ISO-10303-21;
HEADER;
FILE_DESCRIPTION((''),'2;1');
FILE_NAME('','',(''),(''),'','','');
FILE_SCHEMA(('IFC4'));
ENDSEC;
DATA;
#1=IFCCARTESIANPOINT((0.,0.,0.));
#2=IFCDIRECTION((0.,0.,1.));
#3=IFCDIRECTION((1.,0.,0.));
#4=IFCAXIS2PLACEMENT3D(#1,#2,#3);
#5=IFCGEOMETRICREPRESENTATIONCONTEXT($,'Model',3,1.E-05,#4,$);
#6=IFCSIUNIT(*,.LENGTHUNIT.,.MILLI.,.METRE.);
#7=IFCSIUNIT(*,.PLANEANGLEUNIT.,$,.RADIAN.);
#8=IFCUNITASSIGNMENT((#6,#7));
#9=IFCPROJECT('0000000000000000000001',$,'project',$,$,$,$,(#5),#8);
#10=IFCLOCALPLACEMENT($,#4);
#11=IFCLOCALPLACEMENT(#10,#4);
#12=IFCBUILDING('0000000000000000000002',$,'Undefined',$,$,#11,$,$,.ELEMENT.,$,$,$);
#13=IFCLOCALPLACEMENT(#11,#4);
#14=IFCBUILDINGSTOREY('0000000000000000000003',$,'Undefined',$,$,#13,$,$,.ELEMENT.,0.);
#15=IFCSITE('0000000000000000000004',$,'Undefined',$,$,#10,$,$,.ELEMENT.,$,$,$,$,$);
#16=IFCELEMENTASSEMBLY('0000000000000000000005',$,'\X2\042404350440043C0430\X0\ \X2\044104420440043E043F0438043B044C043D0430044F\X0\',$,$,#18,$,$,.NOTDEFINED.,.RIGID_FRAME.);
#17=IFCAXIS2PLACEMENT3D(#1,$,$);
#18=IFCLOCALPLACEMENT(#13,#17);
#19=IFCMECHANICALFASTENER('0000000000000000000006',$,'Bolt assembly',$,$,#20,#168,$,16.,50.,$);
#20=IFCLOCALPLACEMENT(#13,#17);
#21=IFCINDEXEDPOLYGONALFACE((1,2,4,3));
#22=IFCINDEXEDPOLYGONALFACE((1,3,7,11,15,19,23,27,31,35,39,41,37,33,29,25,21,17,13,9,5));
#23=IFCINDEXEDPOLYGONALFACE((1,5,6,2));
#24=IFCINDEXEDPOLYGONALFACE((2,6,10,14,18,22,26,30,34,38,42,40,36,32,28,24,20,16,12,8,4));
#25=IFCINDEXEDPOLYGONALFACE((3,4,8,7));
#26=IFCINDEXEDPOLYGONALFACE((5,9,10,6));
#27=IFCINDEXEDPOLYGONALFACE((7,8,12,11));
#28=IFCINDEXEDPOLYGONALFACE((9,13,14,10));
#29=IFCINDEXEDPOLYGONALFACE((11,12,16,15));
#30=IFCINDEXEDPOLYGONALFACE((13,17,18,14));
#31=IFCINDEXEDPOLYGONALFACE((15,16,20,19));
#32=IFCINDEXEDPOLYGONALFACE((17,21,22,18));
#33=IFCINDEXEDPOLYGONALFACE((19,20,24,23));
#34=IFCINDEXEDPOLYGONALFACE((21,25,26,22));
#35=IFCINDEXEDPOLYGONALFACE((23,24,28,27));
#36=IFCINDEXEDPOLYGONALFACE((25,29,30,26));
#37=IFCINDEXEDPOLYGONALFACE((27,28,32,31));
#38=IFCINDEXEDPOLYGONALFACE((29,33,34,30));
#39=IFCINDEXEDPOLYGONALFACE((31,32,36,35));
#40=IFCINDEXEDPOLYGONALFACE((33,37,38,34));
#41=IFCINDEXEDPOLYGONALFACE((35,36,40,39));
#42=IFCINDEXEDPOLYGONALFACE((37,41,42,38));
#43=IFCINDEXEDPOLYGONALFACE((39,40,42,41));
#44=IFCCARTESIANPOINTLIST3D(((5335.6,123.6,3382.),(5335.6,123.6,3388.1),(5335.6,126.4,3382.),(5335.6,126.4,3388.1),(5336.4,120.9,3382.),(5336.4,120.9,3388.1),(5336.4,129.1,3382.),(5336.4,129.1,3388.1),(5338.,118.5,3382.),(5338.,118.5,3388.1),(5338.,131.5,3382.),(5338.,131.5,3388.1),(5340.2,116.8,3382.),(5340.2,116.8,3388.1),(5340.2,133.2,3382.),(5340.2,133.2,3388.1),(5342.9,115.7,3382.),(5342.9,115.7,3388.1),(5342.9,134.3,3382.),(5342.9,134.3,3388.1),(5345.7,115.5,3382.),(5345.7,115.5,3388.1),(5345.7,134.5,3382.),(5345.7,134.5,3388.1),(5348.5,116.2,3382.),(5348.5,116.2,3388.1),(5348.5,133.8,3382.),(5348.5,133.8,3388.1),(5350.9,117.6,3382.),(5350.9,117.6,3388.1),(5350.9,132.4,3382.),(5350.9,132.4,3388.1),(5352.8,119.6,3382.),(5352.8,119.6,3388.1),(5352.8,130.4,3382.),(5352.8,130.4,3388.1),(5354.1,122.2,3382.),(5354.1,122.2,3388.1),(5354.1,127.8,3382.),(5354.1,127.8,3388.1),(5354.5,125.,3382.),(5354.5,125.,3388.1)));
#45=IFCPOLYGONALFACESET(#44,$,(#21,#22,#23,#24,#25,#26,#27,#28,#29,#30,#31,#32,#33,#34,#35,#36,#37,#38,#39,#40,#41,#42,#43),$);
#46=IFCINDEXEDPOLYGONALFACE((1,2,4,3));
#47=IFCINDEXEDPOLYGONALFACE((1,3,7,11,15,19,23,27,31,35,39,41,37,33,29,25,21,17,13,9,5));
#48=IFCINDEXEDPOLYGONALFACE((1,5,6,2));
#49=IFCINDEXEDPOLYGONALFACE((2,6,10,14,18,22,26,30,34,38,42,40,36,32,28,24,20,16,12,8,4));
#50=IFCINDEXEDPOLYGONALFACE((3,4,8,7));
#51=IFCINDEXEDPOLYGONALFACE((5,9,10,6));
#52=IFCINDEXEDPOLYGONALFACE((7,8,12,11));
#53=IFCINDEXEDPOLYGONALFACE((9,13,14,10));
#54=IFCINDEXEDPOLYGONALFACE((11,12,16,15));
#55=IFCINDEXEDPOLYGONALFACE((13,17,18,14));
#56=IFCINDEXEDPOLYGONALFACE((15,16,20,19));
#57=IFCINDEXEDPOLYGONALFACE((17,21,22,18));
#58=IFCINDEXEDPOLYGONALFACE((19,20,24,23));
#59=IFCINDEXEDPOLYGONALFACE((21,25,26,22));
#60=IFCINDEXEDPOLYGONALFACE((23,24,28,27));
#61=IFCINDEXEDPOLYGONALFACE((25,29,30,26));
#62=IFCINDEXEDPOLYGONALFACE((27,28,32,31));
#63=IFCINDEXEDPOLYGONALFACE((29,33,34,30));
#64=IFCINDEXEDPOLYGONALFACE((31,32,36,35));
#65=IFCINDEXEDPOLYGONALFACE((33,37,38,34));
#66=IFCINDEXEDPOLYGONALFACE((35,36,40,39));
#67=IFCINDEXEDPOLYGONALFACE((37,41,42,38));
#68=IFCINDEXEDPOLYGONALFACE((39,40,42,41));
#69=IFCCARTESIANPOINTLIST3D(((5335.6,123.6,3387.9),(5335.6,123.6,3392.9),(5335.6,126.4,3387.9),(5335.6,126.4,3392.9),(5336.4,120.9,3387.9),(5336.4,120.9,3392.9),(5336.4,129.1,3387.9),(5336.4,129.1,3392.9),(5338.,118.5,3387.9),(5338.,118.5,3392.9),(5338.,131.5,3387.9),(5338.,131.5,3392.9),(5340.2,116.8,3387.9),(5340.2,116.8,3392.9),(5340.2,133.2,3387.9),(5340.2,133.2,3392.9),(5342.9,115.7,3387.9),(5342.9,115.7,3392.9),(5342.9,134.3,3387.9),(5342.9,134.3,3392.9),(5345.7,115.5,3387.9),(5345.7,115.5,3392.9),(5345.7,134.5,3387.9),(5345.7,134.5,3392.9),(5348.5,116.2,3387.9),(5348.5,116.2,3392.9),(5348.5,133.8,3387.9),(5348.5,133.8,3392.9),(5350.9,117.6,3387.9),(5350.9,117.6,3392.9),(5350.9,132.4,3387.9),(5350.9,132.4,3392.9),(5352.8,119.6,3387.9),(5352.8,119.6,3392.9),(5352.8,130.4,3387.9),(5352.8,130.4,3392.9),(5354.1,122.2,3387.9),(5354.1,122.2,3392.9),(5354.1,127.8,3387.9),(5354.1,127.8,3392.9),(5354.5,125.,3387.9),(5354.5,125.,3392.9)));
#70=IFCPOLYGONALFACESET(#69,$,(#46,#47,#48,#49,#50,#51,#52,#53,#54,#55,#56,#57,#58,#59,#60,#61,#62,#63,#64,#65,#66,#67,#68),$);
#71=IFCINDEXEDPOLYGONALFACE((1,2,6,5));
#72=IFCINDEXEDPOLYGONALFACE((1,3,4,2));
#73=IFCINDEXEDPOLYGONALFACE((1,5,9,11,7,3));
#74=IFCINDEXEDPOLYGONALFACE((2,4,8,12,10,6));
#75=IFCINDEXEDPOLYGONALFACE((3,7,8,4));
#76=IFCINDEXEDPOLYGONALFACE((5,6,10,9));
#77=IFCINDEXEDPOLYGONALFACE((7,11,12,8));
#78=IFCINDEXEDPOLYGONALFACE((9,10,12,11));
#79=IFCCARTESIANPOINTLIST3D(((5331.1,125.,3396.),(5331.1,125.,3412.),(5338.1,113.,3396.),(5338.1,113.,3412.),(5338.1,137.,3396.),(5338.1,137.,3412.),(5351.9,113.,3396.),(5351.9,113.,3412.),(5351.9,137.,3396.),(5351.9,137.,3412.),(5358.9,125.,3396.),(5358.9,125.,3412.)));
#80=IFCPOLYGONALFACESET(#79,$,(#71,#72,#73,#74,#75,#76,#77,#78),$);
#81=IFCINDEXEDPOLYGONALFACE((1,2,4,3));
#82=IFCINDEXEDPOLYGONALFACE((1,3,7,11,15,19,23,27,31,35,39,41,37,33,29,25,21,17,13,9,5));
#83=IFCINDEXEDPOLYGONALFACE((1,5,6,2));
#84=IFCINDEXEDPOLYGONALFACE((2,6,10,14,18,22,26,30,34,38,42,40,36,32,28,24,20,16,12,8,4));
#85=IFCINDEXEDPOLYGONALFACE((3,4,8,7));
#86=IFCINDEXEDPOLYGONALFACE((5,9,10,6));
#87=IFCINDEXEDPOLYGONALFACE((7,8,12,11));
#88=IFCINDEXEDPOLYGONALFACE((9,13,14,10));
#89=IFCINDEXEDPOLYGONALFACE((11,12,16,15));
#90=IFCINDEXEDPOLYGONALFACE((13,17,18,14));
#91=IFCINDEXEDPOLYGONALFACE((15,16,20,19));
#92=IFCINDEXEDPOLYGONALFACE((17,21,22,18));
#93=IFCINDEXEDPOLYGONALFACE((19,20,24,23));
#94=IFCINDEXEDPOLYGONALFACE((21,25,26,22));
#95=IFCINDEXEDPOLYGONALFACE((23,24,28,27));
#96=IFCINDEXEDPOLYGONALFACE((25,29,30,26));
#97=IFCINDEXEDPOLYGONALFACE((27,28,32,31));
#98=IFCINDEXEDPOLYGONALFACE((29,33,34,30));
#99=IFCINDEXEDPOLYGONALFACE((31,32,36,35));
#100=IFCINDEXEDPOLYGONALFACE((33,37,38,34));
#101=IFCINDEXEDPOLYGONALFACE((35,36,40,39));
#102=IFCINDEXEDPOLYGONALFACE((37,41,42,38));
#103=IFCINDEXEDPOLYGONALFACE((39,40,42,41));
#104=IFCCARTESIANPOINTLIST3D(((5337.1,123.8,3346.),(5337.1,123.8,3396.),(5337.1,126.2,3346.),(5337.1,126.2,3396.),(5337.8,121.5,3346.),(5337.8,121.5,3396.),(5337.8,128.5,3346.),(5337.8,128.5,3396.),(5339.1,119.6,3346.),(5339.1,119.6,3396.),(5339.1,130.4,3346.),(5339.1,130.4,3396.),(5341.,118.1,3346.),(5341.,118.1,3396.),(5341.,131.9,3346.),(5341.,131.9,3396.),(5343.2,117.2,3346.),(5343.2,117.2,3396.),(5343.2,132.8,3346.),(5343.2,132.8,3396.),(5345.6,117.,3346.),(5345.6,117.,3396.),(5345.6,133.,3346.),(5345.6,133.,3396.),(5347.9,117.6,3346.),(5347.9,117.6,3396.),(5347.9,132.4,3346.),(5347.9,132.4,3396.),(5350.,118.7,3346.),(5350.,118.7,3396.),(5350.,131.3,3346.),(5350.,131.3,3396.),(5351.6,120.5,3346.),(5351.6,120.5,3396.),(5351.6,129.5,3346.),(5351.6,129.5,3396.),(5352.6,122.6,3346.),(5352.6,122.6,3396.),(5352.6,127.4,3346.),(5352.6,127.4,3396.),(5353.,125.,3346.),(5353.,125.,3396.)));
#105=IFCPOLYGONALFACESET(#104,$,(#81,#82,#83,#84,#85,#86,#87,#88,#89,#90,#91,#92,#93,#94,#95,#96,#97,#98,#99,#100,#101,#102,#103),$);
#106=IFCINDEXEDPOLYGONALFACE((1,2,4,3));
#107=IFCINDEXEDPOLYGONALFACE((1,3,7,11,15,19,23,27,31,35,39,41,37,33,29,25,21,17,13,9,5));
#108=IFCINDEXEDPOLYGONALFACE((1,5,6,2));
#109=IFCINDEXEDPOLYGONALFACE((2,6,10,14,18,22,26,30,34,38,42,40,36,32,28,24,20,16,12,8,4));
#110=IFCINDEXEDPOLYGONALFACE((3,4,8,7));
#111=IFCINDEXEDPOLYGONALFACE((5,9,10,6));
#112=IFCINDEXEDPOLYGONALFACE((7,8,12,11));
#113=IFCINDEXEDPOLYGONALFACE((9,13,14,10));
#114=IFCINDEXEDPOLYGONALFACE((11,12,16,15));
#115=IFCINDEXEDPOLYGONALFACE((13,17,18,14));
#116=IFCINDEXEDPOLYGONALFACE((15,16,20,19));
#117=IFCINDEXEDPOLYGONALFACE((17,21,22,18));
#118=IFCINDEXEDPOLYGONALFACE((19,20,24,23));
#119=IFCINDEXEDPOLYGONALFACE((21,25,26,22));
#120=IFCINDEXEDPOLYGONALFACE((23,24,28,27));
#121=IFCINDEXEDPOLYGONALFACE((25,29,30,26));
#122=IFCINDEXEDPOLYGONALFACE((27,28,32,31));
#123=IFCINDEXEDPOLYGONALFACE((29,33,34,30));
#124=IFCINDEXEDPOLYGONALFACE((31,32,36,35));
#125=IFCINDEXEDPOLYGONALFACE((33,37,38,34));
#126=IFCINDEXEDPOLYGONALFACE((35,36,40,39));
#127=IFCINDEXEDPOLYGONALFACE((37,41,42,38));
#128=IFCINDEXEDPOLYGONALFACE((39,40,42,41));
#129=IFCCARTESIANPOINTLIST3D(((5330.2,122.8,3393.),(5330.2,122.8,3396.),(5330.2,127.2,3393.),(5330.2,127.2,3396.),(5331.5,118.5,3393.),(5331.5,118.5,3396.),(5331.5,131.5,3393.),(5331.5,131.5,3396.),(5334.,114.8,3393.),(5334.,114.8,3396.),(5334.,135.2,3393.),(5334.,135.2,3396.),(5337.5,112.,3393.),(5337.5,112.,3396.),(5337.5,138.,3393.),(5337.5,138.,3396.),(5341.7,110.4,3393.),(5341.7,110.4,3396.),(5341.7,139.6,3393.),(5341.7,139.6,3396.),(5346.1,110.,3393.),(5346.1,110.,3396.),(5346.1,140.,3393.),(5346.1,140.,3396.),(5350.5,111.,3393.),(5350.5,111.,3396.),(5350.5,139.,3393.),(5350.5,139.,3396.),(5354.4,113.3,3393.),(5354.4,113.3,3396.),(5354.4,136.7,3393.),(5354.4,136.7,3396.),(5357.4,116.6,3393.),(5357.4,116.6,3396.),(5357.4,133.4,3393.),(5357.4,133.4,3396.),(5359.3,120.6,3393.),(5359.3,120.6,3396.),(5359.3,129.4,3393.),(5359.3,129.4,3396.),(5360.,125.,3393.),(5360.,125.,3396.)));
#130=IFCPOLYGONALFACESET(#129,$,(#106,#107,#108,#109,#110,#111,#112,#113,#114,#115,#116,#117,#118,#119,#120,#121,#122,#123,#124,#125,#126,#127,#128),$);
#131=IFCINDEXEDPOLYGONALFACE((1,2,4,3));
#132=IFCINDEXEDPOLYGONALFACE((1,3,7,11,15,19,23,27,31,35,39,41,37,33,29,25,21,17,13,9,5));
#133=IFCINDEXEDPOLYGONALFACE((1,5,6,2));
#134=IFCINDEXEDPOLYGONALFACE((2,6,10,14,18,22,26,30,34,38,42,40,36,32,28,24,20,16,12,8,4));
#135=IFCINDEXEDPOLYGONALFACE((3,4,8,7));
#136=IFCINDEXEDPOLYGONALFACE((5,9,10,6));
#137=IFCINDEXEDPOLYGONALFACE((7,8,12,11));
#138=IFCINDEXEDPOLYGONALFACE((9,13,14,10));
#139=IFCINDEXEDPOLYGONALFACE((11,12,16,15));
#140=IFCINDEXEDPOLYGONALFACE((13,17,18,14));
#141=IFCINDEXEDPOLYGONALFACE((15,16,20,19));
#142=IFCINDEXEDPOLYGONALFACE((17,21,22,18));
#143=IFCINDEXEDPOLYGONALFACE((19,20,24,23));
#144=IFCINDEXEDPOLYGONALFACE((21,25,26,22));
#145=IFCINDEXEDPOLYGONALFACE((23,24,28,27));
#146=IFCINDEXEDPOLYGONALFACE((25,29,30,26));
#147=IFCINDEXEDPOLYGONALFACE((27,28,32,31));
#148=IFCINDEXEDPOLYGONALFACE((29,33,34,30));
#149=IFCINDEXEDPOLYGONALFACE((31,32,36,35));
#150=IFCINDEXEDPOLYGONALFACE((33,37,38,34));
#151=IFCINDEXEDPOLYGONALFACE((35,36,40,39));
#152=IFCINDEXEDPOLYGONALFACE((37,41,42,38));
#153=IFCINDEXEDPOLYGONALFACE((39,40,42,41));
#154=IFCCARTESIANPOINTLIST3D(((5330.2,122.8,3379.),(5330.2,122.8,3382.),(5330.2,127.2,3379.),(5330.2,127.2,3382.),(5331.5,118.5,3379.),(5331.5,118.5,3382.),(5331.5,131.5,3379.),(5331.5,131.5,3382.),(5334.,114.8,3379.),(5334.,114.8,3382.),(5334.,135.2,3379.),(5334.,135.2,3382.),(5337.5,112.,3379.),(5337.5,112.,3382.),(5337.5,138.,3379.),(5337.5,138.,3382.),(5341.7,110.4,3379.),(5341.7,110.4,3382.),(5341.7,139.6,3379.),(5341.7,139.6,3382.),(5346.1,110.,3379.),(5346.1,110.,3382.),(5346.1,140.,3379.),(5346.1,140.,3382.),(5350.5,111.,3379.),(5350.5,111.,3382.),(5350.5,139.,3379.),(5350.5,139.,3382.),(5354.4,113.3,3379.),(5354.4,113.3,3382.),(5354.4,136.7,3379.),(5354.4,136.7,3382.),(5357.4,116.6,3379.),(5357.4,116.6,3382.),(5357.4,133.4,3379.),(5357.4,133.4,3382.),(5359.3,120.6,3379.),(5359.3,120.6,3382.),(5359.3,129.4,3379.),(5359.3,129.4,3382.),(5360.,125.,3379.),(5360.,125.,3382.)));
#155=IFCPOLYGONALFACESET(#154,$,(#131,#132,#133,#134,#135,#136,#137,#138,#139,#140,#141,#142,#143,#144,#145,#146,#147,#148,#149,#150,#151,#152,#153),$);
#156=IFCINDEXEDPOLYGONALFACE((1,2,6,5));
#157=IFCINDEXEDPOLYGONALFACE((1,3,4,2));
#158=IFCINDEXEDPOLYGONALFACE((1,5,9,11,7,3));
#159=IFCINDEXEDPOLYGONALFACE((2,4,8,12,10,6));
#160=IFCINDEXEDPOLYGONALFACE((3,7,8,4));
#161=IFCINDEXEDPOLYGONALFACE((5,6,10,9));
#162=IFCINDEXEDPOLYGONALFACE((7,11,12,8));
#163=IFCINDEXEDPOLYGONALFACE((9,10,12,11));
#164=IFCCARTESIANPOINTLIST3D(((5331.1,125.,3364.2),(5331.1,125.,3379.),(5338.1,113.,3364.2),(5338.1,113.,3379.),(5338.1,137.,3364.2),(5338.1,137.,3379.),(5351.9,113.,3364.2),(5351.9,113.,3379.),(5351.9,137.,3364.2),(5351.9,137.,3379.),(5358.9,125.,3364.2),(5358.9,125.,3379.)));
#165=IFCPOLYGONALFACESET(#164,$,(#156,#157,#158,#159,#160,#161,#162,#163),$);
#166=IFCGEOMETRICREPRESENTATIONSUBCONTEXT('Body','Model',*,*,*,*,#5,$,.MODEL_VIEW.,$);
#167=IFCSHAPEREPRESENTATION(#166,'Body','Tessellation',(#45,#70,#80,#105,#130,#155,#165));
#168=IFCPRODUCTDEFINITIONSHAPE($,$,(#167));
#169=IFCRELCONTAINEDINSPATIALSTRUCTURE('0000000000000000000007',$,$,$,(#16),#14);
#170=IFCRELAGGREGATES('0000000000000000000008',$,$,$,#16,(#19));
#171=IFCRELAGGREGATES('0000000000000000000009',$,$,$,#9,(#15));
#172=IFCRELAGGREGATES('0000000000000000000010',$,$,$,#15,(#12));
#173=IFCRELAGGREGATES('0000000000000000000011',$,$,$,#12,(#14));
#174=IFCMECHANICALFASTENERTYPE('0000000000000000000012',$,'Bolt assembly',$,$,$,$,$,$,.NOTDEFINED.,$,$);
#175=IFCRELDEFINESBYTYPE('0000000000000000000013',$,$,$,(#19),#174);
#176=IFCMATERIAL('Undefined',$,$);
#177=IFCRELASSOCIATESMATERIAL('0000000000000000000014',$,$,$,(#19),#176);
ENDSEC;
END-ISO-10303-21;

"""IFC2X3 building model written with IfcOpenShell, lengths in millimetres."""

from ifc_helpers import new_model, si_unit, frame, origin_with_axes, origin_2d_with_axis, place, context, subcontext, project, spatial, polyline, circle, outline, extrude, source, transform, mapped, material, type_object, element, aggregate, save


model = new_model("IFC2X3")

# Units and contexts
model_context = context("Model", 3, precision=1e-05, world=origin_with_axes())
body_context = subcontext(model_context, "Body", "Model", "MODEL_VIEW")
ifc_project = project(units=[si_unit("LENGTHUNIT", "METRE", prefix="MILLI"), si_unit("PLANEANGLEUNIT", "RADIAN")], contexts=[model_context])

# Site, building, storey
site_placement = place(None, origin_with_axes())
site = spatial("IfcSite", under=ifc_project, at=site_placement, Name="Undefined", CompositionType="ELEMENT")
building_placement = place(site_placement, origin_with_axes())
building = spatial("IfcBuilding", under=site, at=building_placement, Name="Undefined", CompositionType="ELEMENT")
storey_placement = place(building_placement, origin_with_axes())
storey = spatial("IfcBuildingStorey", under=building, at=storey_placement, Name="Undefined", CompositionType="ELEMENT", Elevation=0.0)

# Element assembly
assembly_1_placement = place(storey_placement, origin_with_axes())
assembly_1 = element("IfcElementAssembly", 1, at=assembly_1_placement, inside=storey, Name="Ферма стропильная", AssemblyPlace="NOTDEFINED", PredefinedType="RIGID_FRAME")

# Mechanical fastener
ifc_material_1 = material(Name="Undefined")
mechanical_fastener_type = type_object("IfcMechanicalFastenerType", Name="Bolt assembly")
shared_shape_1 = source(origin_with_axes(), body_context, "Body", "SweptSolid", [
    extrude(circle(Radius=9.5, at=origin_2d_with_axis()), frame((0.0, -0.1, 0.0), z_axis=(0.0, 1.0, 0.0), x_axis=(1.0, 0.0, 0.0)), (0.0, 0.0, 1.0), 6.1),
    extrude(circle(Radius=9.5, at=origin_2d_with_axis()), frame((0.0, -4.9, 0.0), z_axis=(0.0, 1.0, 0.0), x_axis=(1.0, 0.0, 0.0)), (0.0, 0.0, 1.0), 5.0),
    extrude(outline(polyline([(13.9, 0.0), (6.9, 12.0), (-6.9, 12.0), (-13.9, 0.0), (-6.9, -12.0), (6.9, -12.0), (13.9, 0.0)])), frame((0.0, -24.0, 0.0), z_axis=(0.0, 1.0, 0.0), x_axis=(1.0, 0.0, 0.0)), (0.0, 0.0, 1.0), 16.0),
    extrude(circle(Radius=8.0, at=origin_2d_with_axis()), frame((0.0, -8.0, 0.0), z_axis=(0.0, 1.0, 0.0), x_axis=(1.0, 0.0, 0.0)), (0.0, 0.0, 1.0), 50.0),
    extrude(circle(Radius=15.0, at=origin_2d_with_axis()), frame((0.0, -8.0, 0.0), z_axis=(0.0, 1.0, 0.0), x_axis=(1.0, 0.0, 0.0)), (0.0, 0.0, 1.0), 3.0),
    extrude(circle(Radius=15.0, at=origin_2d_with_axis()), frame((0.0, 6.0, 0.0), z_axis=(0.0, 1.0, 0.0), x_axis=(1.0, 0.0, 0.0)), (0.0, 0.0, 1.0), 3.0),
    extrude(outline(polyline([(13.9, 0.0), (6.9, 12.0), (-6.9, 12.0), (-13.9, 0.0), (-6.9, -12.0), (6.9, -12.0), (13.9, 0.0)])), frame((0.0, 9.0, 0.0), z_axis=(0.0, 1.0, 0.0), x_axis=(1.0, 0.0, 0.0)), (0.0, 0.0, 1.0), 14.8),
])
mechanical_fastener_1_placement = place(assembly_1_placement, frame((5345.0, 125.0, 3388.0), z_axis=(0.0, 1.0, 0.0), x_axis=(1.0, 0.0, 0.0)))
mechanical_fastener_1 = element("IfcMechanicalFastener", 2, at=mechanical_fastener_1_placement, type_object=mechanical_fastener_type, material=ifc_material_1, Name="Bolt assembly", NominalDiameter=16.0, NominalLength=50.0, context=body_context, shape_type="MappedRepresentation", body=[
    mapped(shared_shape_1, transform((0.0, 0.0, 0.0))),
])
aggregate(assembly_1, [mechanical_fastener_1])

save(model, "model.ifc")
